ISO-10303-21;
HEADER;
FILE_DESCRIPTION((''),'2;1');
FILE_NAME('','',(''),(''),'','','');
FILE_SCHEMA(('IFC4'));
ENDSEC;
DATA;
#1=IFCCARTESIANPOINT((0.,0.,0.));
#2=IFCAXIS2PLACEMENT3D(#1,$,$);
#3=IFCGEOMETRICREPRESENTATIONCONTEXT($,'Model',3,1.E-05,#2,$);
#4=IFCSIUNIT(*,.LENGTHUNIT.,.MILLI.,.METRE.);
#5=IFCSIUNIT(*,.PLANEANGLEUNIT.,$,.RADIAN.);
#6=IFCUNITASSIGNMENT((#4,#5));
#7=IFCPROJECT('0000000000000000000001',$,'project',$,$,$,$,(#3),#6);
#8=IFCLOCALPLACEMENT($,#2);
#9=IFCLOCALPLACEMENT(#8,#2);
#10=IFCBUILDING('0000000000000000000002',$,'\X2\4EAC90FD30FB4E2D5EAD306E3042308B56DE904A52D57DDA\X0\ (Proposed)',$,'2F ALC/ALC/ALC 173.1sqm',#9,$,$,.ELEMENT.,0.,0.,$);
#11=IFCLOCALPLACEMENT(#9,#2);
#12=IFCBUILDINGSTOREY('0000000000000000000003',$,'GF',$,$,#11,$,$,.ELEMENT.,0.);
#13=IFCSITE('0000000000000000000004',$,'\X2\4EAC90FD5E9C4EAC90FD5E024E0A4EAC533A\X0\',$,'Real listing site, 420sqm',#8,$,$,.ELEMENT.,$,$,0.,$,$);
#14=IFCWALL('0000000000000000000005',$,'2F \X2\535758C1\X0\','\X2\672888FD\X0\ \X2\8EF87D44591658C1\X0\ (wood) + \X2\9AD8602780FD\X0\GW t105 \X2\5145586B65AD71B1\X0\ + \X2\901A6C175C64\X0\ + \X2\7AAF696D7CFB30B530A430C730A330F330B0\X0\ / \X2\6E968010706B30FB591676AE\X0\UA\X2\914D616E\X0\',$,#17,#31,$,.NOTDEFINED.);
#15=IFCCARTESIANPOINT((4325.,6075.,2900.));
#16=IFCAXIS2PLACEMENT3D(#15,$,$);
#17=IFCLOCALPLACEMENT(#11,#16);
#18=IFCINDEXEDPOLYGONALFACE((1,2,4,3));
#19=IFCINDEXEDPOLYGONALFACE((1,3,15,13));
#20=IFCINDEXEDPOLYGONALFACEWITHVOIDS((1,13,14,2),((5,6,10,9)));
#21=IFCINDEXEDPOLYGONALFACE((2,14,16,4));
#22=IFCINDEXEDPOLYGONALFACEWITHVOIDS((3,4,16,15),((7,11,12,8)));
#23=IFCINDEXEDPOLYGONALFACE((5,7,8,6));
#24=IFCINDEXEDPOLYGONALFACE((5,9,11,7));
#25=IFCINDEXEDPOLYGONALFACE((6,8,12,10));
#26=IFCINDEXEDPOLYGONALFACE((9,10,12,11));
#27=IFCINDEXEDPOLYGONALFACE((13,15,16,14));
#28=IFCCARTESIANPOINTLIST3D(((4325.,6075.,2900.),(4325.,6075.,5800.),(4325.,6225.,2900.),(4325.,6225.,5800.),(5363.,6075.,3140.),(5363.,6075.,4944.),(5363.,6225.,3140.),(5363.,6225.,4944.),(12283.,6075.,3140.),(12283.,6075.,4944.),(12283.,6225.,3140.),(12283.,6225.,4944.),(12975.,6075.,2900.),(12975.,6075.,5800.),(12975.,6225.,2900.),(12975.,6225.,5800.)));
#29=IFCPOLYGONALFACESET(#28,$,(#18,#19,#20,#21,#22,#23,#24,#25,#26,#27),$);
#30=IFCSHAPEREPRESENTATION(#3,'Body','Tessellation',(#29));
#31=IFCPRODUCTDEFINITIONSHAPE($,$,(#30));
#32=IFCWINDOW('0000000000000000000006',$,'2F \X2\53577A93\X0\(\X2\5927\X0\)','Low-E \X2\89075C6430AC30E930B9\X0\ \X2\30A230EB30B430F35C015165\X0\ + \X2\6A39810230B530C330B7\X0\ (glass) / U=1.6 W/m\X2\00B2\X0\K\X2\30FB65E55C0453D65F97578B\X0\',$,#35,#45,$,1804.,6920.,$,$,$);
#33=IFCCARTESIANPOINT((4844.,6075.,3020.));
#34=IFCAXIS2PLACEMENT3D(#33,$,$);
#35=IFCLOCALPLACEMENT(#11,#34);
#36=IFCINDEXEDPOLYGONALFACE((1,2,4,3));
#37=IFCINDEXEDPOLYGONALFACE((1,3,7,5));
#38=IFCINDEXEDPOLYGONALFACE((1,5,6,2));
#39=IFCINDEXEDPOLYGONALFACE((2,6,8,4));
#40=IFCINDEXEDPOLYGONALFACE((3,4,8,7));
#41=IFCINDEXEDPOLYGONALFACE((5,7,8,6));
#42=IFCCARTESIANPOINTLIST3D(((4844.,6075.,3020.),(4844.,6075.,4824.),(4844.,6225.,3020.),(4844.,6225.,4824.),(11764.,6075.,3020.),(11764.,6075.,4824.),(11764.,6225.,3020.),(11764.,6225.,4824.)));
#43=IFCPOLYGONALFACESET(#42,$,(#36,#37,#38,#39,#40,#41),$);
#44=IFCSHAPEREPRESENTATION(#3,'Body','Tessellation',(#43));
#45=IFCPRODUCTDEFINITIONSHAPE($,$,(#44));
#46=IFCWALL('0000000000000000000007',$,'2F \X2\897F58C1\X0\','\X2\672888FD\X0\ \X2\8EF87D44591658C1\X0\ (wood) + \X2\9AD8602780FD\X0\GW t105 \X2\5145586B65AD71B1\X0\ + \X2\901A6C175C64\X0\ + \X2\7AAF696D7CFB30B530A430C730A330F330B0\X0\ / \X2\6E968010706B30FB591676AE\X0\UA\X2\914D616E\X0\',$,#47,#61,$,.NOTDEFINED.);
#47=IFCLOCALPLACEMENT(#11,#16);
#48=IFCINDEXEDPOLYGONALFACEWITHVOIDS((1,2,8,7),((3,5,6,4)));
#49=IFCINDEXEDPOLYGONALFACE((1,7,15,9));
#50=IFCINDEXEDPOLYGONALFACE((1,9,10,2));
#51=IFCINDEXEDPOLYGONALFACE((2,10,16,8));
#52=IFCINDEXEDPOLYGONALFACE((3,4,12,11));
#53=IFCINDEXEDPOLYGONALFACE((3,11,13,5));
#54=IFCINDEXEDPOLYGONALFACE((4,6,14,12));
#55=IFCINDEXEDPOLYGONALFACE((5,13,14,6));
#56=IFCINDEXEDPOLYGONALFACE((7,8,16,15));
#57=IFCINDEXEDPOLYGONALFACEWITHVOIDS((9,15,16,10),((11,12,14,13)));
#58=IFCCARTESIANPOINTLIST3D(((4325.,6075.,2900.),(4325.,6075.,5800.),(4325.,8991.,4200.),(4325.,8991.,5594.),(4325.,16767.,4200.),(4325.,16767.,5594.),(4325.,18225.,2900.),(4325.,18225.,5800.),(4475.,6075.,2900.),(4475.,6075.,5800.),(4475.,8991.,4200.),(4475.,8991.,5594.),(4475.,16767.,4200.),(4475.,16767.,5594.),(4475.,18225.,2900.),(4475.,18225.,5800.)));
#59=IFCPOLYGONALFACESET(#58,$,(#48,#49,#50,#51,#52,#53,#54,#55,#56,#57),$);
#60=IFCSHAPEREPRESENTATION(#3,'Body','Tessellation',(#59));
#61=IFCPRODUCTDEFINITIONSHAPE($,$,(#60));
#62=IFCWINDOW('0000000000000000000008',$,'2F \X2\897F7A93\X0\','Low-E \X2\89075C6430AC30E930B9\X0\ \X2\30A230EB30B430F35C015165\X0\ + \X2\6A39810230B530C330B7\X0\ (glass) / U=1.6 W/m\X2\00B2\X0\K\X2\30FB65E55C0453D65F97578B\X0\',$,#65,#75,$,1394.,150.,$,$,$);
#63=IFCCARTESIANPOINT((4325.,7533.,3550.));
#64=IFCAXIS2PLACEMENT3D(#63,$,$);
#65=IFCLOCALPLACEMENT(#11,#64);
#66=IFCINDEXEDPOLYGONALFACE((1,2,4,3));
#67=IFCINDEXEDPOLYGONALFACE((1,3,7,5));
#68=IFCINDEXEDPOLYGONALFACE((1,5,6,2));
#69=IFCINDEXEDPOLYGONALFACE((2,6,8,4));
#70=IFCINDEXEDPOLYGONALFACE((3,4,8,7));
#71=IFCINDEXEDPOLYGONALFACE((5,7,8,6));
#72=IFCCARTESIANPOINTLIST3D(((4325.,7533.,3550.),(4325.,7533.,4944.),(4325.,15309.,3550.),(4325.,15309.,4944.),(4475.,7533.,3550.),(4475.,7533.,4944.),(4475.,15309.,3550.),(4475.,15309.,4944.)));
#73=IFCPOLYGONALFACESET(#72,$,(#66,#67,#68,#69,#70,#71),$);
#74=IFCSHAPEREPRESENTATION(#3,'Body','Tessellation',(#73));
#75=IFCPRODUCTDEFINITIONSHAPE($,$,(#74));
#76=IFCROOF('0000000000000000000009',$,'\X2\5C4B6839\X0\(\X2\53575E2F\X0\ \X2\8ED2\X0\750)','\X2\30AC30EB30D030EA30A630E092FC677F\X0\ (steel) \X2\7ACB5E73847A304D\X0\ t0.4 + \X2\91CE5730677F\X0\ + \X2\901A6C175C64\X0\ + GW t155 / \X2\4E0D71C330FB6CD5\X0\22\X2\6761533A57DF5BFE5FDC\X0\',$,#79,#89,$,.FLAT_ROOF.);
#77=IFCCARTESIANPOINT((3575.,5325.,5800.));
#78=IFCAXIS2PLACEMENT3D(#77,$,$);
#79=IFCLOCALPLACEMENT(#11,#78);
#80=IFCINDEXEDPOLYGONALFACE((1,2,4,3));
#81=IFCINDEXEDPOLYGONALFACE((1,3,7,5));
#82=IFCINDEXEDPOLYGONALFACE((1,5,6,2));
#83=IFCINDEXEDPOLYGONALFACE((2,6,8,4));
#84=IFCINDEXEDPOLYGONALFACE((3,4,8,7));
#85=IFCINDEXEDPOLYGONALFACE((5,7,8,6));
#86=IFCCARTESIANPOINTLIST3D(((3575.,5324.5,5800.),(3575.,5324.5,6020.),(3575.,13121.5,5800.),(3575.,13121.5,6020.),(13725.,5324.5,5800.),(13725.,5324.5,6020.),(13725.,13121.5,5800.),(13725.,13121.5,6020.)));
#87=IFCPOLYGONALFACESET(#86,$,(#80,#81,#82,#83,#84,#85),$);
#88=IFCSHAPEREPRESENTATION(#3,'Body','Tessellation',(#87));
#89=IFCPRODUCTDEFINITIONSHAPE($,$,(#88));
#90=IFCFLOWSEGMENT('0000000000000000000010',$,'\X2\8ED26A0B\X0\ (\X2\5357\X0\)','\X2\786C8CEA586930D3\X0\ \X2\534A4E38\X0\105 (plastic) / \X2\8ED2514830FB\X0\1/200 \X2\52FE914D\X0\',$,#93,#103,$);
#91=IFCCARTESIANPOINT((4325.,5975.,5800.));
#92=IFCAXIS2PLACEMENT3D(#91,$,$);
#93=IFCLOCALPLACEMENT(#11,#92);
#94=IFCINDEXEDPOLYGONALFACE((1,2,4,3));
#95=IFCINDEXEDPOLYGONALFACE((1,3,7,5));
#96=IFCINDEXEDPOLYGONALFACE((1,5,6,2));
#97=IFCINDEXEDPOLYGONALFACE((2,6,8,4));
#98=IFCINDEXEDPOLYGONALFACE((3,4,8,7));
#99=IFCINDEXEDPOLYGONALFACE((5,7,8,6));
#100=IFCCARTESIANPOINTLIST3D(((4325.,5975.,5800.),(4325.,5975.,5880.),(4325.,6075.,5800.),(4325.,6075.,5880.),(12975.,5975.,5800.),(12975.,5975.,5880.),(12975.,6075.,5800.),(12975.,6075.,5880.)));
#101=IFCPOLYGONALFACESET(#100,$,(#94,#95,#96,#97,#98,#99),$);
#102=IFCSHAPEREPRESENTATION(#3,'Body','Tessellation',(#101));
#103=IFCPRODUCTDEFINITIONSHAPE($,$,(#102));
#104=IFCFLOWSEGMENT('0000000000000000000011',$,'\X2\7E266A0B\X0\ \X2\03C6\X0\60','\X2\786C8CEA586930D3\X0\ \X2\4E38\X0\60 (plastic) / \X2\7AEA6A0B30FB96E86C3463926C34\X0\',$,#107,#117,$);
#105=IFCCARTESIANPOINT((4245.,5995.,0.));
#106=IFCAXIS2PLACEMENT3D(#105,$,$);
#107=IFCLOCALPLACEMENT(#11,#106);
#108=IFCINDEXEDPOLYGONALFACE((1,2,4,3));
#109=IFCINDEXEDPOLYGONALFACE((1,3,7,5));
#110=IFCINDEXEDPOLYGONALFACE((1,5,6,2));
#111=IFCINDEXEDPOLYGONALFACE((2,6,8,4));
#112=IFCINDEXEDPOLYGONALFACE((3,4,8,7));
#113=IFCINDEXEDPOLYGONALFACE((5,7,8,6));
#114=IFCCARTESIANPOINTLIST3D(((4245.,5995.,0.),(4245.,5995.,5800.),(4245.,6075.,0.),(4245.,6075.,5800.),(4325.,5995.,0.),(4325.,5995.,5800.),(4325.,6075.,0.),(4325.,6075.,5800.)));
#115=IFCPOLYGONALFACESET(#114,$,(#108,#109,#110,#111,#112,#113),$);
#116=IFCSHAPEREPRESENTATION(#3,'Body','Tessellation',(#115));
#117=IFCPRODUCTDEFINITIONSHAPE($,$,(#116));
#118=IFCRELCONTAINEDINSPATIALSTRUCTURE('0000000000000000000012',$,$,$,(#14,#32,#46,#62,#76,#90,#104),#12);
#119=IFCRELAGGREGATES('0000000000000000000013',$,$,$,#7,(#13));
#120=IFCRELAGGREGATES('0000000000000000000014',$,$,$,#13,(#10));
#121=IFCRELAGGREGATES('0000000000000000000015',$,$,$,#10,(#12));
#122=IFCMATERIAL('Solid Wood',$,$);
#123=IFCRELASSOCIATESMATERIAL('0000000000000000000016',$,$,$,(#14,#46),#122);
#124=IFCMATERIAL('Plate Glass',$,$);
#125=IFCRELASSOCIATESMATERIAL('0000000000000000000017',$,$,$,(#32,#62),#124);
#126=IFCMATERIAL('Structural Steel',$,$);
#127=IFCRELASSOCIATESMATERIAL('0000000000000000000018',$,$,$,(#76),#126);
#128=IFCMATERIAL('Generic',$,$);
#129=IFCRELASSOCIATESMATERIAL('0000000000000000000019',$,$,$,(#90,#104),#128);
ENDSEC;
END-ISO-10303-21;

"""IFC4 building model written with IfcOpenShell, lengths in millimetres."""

from ifc_helpers import new_model, si_unit, frame, frame_2d, origin, place, context, project, spatial, rectangle, extrude, material, element, fill, save


model = new_model("IFC4")

# Units and contexts
model_context = context("Model", 3, precision=1e-05, world=origin())
ifc_project = project(units=[si_unit("LENGTHUNIT", "METRE", prefix="MILLI"), si_unit("PLANEANGLEUNIT", "RADIAN")], contexts=[model_context])

# Site, building, storey
site_placement = place(None, origin())
site = spatial("IfcSite", under=ifc_project, at=site_placement, Name="京都府京都市上京区", ObjectType="Real listing site, 420sqm", CompositionType="ELEMENT", RefElevation=0.0)
building_placement = place(site_placement, origin())
building = spatial("IfcBuilding", under=site, at=building_placement, Name="京都・中庭のある回遊動線 (Proposed)", ObjectType="2F ALC/ALC/ALC 173.1sqm", CompositionType="ELEMENT", ElevationOfRefHeight=0.0, ElevationOfTerrain=0.0)
storey_placement = place(building_placement, origin())
storey = spatial("IfcBuildingStorey", under=building, at=storey_placement, Name="GF", CompositionType="ELEMENT", Elevation=0.0)

# Shared definitions
ifc_material_1 = material(Name="Solid Wood")

# Shared definitions
ifc_material_2 = material(Name="Plate Glass")

# Walls, openings, windows
wall_1_placement = place(storey_placement, frame((4325.0, 6075.0, 2900.0)))
wall_1 = element("IfcWall", 1, at=wall_1_placement, inside=storey, material=ifc_material_1, Name="2F 南壁", Description="木製 軸組外壁 (wood) + 高性能GW t105 充填断熱 + 通気層 + 窯業系サイディング / 準耐火・外皮UA配慮", PredefinedType="NOTDEFINED", context=model_context, shape_type="SweptSolid", body=[
    extrude(rectangle(XDim=8650.0, YDim=150.0, at=frame_2d((4325.0, 75.0))), frame((4325.0, 6075.0, 2900.0)), (0.0, 0.0, 1.0), 2900.0),
])
opening_1_placement = place(storey_placement, frame((4844.0, 6075.0, 3020.0)))
opening_1 = element("IfcOpeningElement", 2, at=opening_1_placement, cuts=wall_1, PredefinedType="NOTDEFINED", context=model_context, shape_type="SweptSolid", body=[
    extrude(rectangle(XDim=6920.0, YDim=150.0, at=frame_2d((3460.0, 75.0))), frame((4844.0, 6075.0, 3020.0)), (0.0, 0.0, 1.0), 1804.0),
])
window_1_placement = place(storey_placement, frame((4844.0, 6075.0, 3020.0)))
window_1 = element("IfcWindow", 3, at=window_1_placement, inside=storey, material=ifc_material_2, Name="2F 南窓(大)", Description="Low-E 複層ガラス アルゴン封入 + 樹脂サッシ (glass) / U=1.6 W/m²K・日射取得型", OverallHeight=1804.0, OverallWidth=6920.0, context=model_context, shape_type="SweptSolid", body=[
    extrude(rectangle(XDim=6920.0, YDim=150.0, at=frame_2d((3460.0, 75.0))), frame((4844.0, 6075.0, 3020.0)), (0.0, 0.0, 1.0), 1804.0),
])
fill(opening_1, window_1)
wall_2_placement = place(storey_placement, frame((4325.0, 6075.0, 2900.0)))
wall_2 = element("IfcWall", 4, at=wall_2_placement, inside=storey, material=ifc_material_1, Name="2F 西壁", Description="木製 軸組外壁 (wood) + 高性能GW t105 充填断熱 + 通気層 + 窯業系サイディング / 準耐火・外皮UA配慮", PredefinedType="NOTDEFINED", context=model_context, shape_type="SweptSolid", body=[
    extrude(rectangle(XDim=150.0, YDim=12150.0, at=frame_2d((75.0, 6075.0))), frame((4325.0, 6075.0, 2900.0)), (0.0, 0.0, 1.0), 2900.0),
])
opening_2_placement = place(storey_placement, frame((4325.0, 7533.0, 3550.0)))
opening_2 = element("IfcOpeningElement", 5, at=opening_2_placement, cuts=wall_2, PredefinedType="NOTDEFINED", context=model_context, shape_type="SweptSolid", body=[
    extrude(rectangle(XDim=150.0, YDim=7776.0, at=frame_2d((75.0, 3888.0))), frame((4325.0, 7533.0, 3550.0)), (0.0, 0.0, 1.0), 1394.0),
])
window_2_placement = place(storey_placement, frame((4325.0, 7533.0, 3550.0)))
window_2 = element("IfcWindow", 6, at=window_2_placement, inside=storey, material=ifc_material_2, Name="2F 西窓", Description="Low-E 複層ガラス アルゴン封入 + 樹脂サッシ (glass) / U=1.6 W/m²K・日射取得型", OverallHeight=1394.0, OverallWidth=150.0, context=model_context, shape_type="SweptSolid", body=[
    extrude(rectangle(XDim=150.0, YDim=7776.0, at=frame_2d((75.0, 3888.0))), frame((4325.0, 7533.0, 3550.0)), (0.0, 0.0, 1.0), 1394.0),
])
fill(opening_2, window_2)

# Roof
ifc_material_3 = material(Name="Structural Steel")
for number, where, name in (
    (7, (3575.0, 5325.0, 5800.0), "屋根(南帯 軒750)"),
):
    element("IfcRoof", number, at=place(storey_placement, frame(where)), inside=storey, material=ifc_material_3, Name=name, Description="ガルバリウム鋼板 (steel) 立平葺き t0.4 + 野地板 + 通気層 + GW t155 / 不燃・法22条区域対応", PredefinedType="FLAT_ROOF", context=model_context, shape_type="SweptSolid", body=[
        extrude(rectangle(XDim=10150.0, YDim=7797.0, at=frame_2d((5075.0, 3898.0))), frame((3575.0, 5325.0, 5800.0)), (0.0, 0.0, 1.0), 220.0),
    ])

# Flow segments
ifc_material_4 = material(Name="Generic")
flow_segment_1_placement = place(storey_placement, frame((4325.0, 5975.0, 5800.0)))
element("IfcFlowSegment", 8, at=flow_segment_1_placement, inside=storey, material=ifc_material_4, Name="軒樋 (南)", Description="硬質塩ビ 半丸105 (plastic) / 軒先・1/200 勾配", context=model_context, shape_type="SweptSolid", body=[
    extrude(rectangle(XDim=8650.0, YDim=100.0, at=frame_2d((4325.0, 50.0))), frame((4325.0, 5975.0, 5800.0)), (0.0, 0.0, 1.0), 80.0),
])
flow_segment_2_placement = place(storey_placement, frame((4245.0, 5995.0, 0.0)))
element("IfcFlowSegment", 9, at=flow_segment_2_placement, inside=storey, material=ifc_material_4, Name="縦樋 φ60", Description="硬質塩ビ 丸60 (plastic) / 竪樋・雨水排水", context=model_context, shape_type="SweptSolid", body=[
    extrude(rectangle(XDim=80.0, YDim=80.0, at=frame_2d((40.0, 40.0))), frame((4245.0, 5995.0, 0.0)), (0.0, 0.0, 1.0), 5800.0),
])

save(model, "model.ifc")
